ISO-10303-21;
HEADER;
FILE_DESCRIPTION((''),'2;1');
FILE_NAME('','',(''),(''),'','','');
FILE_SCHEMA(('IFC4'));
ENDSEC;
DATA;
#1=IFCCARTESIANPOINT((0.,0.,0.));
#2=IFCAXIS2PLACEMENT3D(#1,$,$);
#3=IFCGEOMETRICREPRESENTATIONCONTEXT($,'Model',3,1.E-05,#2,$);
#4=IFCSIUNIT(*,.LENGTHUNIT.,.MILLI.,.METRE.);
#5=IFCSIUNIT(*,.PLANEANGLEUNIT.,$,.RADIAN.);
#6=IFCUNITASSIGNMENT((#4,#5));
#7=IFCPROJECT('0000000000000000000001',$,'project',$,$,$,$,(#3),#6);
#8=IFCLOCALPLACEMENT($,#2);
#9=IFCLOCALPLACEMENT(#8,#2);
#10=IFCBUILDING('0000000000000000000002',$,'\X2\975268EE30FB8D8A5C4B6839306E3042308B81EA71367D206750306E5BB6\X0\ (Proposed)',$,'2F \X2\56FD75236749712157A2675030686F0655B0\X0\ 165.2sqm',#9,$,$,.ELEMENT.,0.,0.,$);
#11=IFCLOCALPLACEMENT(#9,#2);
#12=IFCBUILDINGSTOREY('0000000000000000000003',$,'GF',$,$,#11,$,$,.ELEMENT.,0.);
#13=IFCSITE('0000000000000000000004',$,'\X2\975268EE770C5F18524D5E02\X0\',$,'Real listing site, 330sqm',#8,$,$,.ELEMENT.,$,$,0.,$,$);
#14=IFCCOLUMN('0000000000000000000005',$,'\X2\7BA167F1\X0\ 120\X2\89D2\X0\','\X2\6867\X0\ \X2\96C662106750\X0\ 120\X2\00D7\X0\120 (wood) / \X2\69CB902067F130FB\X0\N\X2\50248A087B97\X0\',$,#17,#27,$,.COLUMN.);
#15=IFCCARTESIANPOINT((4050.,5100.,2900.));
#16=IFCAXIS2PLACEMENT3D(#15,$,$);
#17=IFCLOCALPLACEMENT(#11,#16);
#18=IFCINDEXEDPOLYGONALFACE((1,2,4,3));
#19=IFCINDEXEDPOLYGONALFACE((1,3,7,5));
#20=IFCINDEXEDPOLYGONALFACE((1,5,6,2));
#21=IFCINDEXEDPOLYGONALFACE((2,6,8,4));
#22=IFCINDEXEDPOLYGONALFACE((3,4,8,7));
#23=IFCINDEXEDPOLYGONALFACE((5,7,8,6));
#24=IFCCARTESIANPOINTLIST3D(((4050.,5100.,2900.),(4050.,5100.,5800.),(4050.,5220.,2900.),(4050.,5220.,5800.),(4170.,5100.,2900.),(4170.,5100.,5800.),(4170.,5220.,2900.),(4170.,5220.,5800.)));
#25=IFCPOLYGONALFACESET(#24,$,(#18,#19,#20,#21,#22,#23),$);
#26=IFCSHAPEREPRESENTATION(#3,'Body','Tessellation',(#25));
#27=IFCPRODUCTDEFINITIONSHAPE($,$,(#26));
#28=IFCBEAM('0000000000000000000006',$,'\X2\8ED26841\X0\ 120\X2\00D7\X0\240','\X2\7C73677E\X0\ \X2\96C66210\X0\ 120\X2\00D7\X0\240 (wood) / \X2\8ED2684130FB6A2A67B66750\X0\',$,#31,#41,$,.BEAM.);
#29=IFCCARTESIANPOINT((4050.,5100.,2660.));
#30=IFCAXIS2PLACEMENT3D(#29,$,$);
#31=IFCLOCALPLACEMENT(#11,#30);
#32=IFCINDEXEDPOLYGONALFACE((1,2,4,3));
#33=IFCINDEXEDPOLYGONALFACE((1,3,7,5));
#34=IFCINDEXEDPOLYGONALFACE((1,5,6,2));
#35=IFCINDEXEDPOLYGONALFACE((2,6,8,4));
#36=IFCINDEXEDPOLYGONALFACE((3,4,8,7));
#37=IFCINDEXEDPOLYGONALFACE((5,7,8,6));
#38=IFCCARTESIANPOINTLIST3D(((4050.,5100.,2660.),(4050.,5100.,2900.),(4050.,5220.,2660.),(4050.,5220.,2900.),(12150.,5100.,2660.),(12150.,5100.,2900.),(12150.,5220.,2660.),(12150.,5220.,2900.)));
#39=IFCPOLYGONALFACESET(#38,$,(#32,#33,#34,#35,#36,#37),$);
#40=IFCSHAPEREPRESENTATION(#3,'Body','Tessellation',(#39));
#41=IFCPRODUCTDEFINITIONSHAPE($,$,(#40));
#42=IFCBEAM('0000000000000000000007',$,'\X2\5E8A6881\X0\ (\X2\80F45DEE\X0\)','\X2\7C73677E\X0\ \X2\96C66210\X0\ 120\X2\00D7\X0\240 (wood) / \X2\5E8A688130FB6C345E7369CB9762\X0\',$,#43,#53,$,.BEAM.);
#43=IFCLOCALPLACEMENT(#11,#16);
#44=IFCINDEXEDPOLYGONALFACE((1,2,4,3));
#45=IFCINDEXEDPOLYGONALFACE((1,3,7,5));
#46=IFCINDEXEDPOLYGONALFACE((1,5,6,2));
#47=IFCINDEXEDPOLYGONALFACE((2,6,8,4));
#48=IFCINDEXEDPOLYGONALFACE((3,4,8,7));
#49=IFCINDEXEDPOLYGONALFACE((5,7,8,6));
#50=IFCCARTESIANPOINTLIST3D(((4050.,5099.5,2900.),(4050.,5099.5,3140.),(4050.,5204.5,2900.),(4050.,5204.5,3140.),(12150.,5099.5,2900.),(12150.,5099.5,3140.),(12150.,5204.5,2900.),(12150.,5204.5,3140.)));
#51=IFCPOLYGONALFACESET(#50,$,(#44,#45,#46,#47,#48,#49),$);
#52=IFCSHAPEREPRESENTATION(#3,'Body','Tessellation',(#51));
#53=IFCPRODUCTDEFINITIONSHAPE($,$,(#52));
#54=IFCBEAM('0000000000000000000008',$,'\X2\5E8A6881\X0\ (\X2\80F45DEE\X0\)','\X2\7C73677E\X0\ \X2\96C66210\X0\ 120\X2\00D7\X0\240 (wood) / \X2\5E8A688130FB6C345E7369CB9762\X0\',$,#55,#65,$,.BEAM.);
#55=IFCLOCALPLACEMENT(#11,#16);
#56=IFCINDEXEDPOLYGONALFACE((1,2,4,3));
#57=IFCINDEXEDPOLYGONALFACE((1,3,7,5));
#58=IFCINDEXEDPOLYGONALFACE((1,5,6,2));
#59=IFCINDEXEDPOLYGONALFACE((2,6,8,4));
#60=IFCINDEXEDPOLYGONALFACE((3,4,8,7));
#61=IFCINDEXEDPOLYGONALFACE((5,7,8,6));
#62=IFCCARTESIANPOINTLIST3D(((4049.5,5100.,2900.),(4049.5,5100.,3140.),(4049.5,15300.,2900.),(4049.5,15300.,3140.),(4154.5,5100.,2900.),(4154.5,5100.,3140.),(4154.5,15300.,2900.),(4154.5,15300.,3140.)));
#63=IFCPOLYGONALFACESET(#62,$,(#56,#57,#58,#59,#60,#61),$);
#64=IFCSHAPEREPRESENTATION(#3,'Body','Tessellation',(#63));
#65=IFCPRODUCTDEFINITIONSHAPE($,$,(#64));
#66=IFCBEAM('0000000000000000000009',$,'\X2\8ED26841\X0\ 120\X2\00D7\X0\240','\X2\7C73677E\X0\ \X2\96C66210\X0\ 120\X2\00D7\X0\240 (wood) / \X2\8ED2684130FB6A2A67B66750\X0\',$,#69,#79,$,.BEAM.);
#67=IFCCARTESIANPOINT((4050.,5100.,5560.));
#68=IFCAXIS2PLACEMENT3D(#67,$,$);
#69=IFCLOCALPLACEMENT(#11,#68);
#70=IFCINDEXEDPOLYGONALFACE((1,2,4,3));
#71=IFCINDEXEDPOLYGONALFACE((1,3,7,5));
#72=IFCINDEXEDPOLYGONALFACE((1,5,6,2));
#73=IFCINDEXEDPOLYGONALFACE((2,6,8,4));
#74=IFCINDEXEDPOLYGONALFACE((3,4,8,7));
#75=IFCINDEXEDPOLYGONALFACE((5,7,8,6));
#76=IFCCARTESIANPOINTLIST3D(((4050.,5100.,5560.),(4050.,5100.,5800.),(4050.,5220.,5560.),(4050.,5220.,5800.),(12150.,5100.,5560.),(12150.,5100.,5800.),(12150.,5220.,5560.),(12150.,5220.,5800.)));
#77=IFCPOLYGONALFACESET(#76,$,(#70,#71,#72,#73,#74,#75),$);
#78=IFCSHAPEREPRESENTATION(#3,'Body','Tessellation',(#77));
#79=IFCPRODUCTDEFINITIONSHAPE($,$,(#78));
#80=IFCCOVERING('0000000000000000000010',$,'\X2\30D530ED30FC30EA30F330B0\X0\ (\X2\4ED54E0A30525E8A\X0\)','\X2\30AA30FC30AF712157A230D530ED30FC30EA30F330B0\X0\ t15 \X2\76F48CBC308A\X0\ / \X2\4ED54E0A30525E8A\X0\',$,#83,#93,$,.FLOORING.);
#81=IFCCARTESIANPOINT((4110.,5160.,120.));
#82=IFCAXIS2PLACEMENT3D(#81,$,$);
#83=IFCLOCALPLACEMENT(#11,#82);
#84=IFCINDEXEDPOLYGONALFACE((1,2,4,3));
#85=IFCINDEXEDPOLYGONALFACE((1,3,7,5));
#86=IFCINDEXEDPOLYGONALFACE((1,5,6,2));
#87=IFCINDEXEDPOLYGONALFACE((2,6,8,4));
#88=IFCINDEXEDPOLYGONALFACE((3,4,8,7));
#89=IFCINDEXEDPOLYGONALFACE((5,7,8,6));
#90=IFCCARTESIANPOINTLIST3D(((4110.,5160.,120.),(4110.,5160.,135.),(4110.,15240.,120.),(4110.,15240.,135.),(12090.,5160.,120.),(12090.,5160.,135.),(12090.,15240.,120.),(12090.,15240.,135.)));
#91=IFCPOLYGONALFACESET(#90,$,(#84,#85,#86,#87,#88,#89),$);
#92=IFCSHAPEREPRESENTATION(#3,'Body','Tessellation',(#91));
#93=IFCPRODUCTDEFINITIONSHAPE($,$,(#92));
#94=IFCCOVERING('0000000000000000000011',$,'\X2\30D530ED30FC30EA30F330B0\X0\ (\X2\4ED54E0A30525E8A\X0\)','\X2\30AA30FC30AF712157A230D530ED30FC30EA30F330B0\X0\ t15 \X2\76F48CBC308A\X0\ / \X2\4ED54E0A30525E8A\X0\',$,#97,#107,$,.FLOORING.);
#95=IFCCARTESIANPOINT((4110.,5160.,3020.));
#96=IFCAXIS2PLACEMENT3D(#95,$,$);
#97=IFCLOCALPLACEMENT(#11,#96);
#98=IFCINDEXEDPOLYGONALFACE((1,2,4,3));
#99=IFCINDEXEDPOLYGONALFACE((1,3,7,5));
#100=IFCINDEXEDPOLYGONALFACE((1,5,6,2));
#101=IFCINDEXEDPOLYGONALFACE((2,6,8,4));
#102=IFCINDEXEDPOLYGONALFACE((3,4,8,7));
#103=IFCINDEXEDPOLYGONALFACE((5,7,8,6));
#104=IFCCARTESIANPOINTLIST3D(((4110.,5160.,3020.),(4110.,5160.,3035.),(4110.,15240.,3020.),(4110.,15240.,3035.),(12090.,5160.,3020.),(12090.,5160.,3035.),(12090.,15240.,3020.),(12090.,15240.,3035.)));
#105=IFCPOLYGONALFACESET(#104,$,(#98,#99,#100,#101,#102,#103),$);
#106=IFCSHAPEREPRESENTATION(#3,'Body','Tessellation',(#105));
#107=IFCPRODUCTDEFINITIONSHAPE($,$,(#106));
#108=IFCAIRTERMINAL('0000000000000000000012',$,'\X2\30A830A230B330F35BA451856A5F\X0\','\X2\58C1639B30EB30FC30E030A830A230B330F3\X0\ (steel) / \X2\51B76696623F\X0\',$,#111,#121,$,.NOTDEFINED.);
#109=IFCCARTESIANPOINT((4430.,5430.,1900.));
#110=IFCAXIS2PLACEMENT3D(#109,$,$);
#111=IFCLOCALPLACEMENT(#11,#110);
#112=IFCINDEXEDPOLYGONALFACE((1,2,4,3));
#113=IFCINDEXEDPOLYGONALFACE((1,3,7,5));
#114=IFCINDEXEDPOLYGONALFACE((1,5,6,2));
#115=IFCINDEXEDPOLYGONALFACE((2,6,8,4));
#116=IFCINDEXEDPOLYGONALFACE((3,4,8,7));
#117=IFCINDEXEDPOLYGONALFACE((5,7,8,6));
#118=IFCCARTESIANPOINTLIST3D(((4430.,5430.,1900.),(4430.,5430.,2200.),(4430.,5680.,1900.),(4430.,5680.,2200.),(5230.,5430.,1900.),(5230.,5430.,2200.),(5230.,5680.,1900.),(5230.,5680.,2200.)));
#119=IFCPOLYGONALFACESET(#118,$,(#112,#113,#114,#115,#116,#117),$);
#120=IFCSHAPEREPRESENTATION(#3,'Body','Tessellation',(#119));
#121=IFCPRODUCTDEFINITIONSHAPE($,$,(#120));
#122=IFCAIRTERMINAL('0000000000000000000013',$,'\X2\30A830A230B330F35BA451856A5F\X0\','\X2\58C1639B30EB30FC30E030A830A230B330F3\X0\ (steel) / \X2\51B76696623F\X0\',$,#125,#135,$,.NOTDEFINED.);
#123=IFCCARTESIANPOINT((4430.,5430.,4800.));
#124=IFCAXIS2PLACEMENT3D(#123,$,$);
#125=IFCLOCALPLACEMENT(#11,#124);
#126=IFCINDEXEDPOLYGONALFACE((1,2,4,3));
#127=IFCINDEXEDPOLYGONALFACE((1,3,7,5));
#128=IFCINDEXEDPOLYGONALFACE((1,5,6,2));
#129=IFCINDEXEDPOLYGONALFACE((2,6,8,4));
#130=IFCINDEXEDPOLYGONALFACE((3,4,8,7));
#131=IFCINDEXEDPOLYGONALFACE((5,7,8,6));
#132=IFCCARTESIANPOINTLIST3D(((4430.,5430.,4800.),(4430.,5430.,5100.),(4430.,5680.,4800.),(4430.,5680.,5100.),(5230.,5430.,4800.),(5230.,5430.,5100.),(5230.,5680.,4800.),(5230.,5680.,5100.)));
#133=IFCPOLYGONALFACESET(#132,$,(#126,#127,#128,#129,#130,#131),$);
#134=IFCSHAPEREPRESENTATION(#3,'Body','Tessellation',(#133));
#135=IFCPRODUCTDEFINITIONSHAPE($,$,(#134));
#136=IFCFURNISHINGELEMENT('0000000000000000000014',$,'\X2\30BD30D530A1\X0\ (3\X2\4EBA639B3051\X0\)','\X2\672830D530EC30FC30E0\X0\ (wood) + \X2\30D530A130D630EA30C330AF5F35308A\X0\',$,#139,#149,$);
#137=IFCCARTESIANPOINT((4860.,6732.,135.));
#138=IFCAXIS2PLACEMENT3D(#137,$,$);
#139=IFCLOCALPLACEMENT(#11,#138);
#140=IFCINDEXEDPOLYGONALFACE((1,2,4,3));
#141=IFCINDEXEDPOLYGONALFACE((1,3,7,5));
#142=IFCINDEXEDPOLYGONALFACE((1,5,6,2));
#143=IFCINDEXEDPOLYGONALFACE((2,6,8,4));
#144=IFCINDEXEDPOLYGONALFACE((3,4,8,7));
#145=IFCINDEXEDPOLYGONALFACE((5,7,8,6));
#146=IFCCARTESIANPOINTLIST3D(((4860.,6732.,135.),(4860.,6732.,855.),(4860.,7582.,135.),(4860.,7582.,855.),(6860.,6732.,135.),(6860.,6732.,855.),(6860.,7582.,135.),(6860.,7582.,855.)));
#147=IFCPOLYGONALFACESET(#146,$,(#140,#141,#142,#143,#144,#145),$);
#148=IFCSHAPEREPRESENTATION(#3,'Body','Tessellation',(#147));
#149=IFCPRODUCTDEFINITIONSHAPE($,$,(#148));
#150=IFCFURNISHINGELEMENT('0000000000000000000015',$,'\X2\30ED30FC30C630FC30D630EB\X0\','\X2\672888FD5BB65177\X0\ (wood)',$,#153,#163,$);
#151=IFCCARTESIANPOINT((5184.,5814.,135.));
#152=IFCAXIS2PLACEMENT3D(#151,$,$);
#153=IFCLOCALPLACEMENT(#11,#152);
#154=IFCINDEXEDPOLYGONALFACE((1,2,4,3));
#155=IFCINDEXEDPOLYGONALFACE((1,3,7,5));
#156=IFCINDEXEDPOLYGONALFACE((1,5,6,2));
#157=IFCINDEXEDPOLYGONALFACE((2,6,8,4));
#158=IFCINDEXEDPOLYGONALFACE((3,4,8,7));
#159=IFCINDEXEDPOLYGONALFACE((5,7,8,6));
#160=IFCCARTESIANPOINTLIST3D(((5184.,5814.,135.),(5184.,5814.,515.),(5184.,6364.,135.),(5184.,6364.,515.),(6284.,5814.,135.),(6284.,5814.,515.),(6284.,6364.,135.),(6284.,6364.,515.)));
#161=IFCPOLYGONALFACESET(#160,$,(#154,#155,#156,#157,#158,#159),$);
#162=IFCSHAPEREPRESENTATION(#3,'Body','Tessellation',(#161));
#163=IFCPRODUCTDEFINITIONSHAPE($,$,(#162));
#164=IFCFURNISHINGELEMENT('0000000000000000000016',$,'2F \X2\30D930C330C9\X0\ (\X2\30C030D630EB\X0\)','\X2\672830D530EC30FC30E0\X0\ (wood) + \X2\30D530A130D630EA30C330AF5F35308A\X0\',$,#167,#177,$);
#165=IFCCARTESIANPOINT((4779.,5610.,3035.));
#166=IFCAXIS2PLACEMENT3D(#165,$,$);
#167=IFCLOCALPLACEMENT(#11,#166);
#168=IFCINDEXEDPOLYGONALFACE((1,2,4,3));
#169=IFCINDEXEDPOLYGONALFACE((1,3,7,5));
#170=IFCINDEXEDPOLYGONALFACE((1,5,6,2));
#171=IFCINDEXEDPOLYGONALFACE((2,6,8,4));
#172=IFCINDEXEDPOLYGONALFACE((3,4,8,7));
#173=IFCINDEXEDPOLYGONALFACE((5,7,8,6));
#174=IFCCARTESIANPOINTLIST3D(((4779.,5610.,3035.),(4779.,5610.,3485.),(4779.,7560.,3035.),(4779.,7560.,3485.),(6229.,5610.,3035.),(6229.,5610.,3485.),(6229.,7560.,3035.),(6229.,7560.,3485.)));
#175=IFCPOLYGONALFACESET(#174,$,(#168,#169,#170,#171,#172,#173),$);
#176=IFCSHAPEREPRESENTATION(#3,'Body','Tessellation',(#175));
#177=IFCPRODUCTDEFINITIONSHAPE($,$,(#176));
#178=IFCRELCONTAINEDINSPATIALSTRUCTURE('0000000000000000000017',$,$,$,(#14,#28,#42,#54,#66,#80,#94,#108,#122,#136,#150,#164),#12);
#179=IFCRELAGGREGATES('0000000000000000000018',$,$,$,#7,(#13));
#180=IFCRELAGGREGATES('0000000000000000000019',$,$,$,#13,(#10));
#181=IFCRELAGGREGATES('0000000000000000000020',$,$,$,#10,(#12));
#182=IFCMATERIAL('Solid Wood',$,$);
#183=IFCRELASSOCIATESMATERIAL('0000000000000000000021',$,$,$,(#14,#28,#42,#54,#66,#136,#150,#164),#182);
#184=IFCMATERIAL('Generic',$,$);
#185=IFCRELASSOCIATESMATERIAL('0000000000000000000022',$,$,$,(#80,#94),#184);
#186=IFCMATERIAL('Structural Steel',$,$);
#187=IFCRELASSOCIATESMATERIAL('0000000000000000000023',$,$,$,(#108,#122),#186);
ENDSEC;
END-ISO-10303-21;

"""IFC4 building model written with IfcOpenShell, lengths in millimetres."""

from ifc_helpers import new_model, si_unit, frame, frame_2d, origin, place, context, project, spatial, rectangle, extrude, material, element, save


model = new_model("IFC4")

# Units and contexts
model_context = context("Model", 3, precision=1e-05, world=origin())
ifc_project = project(units=[si_unit("LENGTHUNIT", "METRE", prefix="MILLI"), si_unit("PLANEANGLEUNIT", "RADIAN")], contexts=[model_context])

# Site, building, storey
site_placement = place(None, origin())
site = spatial("IfcSite", under=ifc_project, at=site_placement, Name="青森県弘前市", ObjectType="Real listing site, 330sqm", CompositionType="ELEMENT", RefElevation=0.0)
building_placement = place(site_placement, origin())
building = spatial("IfcBuilding", under=site, at=building_placement, Name="青森・越屋根のある自然素材の家 (Proposed)", ObjectType="2F 国産杉無垢材と漆喰 165.2sqm", CompositionType="ELEMENT", ElevationOfRefHeight=0.0, ElevationOfTerrain=0.0)
storey_placement = place(building_placement, origin())
storey = spatial("IfcBuildingStorey", under=building, at=storey_placement, Name="GF", CompositionType="ELEMENT", Elevation=0.0)

# Column
ifc_material_1 = material(Name="Solid Wood")
column_1_placement = place(storey_placement, frame((4050.0, 5100.0, 2900.0)))
element("IfcColumn", 1, at=column_1_placement, inside=storey, material=ifc_material_1, Name="管柱 120角", Description="桧 集成材 120×120 (wood) / 構造柱・N値計算", PredefinedType="COLUMN", context=model_context, shape_type="SweptSolid", body=[
    extrude(rectangle(XDim=120.0, YDim=120.0, at=frame_2d((60.0, 60.0))), frame((4050.0, 5100.0, 2900.0)), (0.0, 0.0, 1.0), 2900.0),
])

# Beams
beam_1_placement = place(storey_placement, frame((4050.0, 5100.0, 2660.0)))
element("IfcBeam", 2, at=beam_1_placement, inside=storey, material=ifc_material_1, Name="軒桁 120×240", Description="米松 集成 120×240 (wood) / 軒桁・横架材", PredefinedType="BEAM", context=model_context, shape_type="SweptSolid", body=[
    extrude(rectangle(XDim=8100.0, YDim=120.0, at=frame_2d((4050.0, 60.0))), frame((4050.0, 5100.0, 2660.0)), (0.0, 0.0, 1.0), 240.0),
])
beam_2_placement = place(storey_placement, frame((4050.0, 5100.0, 2900.0)))
element("IfcBeam", 3, at=beam_2_placement, inside=storey, material=ifc_material_1, Name="床梁 (胴差)", Description="米松 集成 120×240 (wood) / 床梁・水平構面", PredefinedType="BEAM", context=model_context, shape_type="SweptSolid", body=[
    extrude(rectangle(XDim=8100.0, YDim=105.0, at=frame_2d((4050.0, 52.0))), frame((4050.0, 5100.0, 2900.0)), (0.0, 0.0, 1.0), 240.0),
])
beam_3_placement = place(storey_placement, frame((4050.0, 5100.0, 2900.0)))
element("IfcBeam", 4, at=beam_3_placement, inside=storey, material=ifc_material_1, Name="床梁 (胴差)", Description="米松 集成 120×240 (wood) / 床梁・水平構面", PredefinedType="BEAM", context=model_context, shape_type="SweptSolid", body=[
    extrude(rectangle(XDim=105.0, YDim=10200.0, at=frame_2d((52.0, 5100.0))), frame((4050.0, 5100.0, 2900.0)), (0.0, 0.0, 1.0), 240.0),
])
beam_4_placement = place(storey_placement, frame((4050.0, 5100.0, 5560.0)))
element("IfcBeam", 5, at=beam_4_placement, inside=storey, material=ifc_material_1, Name="軒桁 120×240", Description="米松 集成 120×240 (wood) / 軒桁・横架材", PredefinedType="BEAM", context=model_context, shape_type="SweptSolid", body=[
    extrude(rectangle(XDim=8100.0, YDim=120.0, at=frame_2d((4050.0, 60.0))), frame((4050.0, 5100.0, 5560.0)), (0.0, 0.0, 1.0), 240.0),
])

# Coverings
ifc_material_2 = material(Name="Generic")
covering_1_placement = place(storey_placement, frame((4110.0, 5160.0, 120.0)))
element("IfcCovering", 6, at=covering_1_placement, inside=storey, material=ifc_material_2, Name="フローリング (仕上げ床)", Description="オーク無垢フローリング t15 直貼り / 仕上げ床", PredefinedType="FLOORING", context=model_context, shape_type="SweptSolid", body=[
    extrude(rectangle(XDim=7980.0, YDim=10080.0, at=frame_2d((3990.0, 5040.0))), frame((4110.0, 5160.0, 120.0)), (0.0, 0.0, 1.0), 15.0),
])
covering_2_placement = place(storey_placement, frame((4110.0, 5160.0, 3020.0)))
element("IfcCovering", 7, at=covering_2_placement, inside=storey, material=ifc_material_2, Name="フローリング (仕上げ床)", Description="オーク無垢フローリング t15 直貼り / 仕上げ床", PredefinedType="FLOORING", context=model_context, shape_type="SweptSolid", body=[
    extrude(rectangle(XDim=7980.0, YDim=10080.0, at=frame_2d((3990.0, 5040.0))), frame((4110.0, 5160.0, 3020.0)), (0.0, 0.0, 1.0), 15.0),
])

# Air terminals
ifc_material_3 = material(Name="Structural Steel")
air_terminal_1_placement = place(storey_placement, frame((4430.0, 5430.0, 1900.0)))
element("IfcAirTerminal", 8, at=air_terminal_1_placement, inside=storey, material=ifc_material_3, Name="エアコン室内機", Description="壁掛ルームエアコン (steel) / 冷暖房", PredefinedType="NOTDEFINED", context=model_context, shape_type="SweptSolid", body=[
    extrude(rectangle(XDim=800.0, YDim=250.0, at=frame_2d((400.0, 125.0))), frame((4430.0, 5430.0, 1900.0)), (0.0, 0.0, 1.0), 300.0),
])
air_terminal_2_placement = place(storey_placement, frame((4430.0, 5430.0, 4800.0)))
element("IfcAirTerminal", 9, at=air_terminal_2_placement, inside=storey, material=ifc_material_3, Name="エアコン室内機", Description="壁掛ルームエアコン (steel) / 冷暖房", PredefinedType="NOTDEFINED", context=model_context, shape_type="SweptSolid", body=[
    extrude(rectangle(XDim=800.0, YDim=250.0, at=frame_2d((400.0, 125.0))), frame((4430.0, 5430.0, 4800.0)), (0.0, 0.0, 1.0), 300.0),
])

# Furnishing elements
furnishing_1_placement = place(storey_placement, frame((4860.0, 6732.0, 135.0)))
element("IfcFurnishingElement", 10, at=furnishing_1_placement, inside=storey, material=ifc_material_1, Name="ソファ (3人掛け)", Description="木フレーム (wood) + ファブリック張り", context=model_context, shape_type="SweptSolid", body=[
    extrude(rectangle(XDim=2000.0, YDim=850.0, at=frame_2d((1000.0, 425.0))), frame((4860.0, 6732.0, 135.0)), (0.0, 0.0, 1.0), 720.0),
])
furnishing_2_placement = place(storey_placement, frame((5184.0, 5814.0, 135.0)))
element("IfcFurnishingElement", 11, at=furnishing_2_placement, inside=storey, material=ifc_material_1, Name="ローテーブル", Description="木製家具 (wood)", context=model_context, shape_type="SweptSolid", body=[
    extrude(rectangle(XDim=1100.0, YDim=550.0, at=frame_2d((550.0, 275.0))), frame((5184.0, 5814.0, 135.0)), (0.0, 0.0, 1.0), 380.0),
])
furnishing_3_placement = place(storey_placement, frame((4779.0, 5610.0, 3035.0)))
element("IfcFurnishingElement", 12, at=furnishing_3_placement, inside=storey, material=ifc_material_1, Name="2F ベッド (ダブル)", Description="木フレーム (wood) + ファブリック張り", context=model_context, shape_type="SweptSolid", body=[
    extrude(rectangle(XDim=1450.0, YDim=1950.0, at=frame_2d((725.0, 975.0))), frame((4779.0, 5610.0, 3035.0)), (0.0, 0.0, 1.0), 450.0),
])

save(model, "model.ifc")
